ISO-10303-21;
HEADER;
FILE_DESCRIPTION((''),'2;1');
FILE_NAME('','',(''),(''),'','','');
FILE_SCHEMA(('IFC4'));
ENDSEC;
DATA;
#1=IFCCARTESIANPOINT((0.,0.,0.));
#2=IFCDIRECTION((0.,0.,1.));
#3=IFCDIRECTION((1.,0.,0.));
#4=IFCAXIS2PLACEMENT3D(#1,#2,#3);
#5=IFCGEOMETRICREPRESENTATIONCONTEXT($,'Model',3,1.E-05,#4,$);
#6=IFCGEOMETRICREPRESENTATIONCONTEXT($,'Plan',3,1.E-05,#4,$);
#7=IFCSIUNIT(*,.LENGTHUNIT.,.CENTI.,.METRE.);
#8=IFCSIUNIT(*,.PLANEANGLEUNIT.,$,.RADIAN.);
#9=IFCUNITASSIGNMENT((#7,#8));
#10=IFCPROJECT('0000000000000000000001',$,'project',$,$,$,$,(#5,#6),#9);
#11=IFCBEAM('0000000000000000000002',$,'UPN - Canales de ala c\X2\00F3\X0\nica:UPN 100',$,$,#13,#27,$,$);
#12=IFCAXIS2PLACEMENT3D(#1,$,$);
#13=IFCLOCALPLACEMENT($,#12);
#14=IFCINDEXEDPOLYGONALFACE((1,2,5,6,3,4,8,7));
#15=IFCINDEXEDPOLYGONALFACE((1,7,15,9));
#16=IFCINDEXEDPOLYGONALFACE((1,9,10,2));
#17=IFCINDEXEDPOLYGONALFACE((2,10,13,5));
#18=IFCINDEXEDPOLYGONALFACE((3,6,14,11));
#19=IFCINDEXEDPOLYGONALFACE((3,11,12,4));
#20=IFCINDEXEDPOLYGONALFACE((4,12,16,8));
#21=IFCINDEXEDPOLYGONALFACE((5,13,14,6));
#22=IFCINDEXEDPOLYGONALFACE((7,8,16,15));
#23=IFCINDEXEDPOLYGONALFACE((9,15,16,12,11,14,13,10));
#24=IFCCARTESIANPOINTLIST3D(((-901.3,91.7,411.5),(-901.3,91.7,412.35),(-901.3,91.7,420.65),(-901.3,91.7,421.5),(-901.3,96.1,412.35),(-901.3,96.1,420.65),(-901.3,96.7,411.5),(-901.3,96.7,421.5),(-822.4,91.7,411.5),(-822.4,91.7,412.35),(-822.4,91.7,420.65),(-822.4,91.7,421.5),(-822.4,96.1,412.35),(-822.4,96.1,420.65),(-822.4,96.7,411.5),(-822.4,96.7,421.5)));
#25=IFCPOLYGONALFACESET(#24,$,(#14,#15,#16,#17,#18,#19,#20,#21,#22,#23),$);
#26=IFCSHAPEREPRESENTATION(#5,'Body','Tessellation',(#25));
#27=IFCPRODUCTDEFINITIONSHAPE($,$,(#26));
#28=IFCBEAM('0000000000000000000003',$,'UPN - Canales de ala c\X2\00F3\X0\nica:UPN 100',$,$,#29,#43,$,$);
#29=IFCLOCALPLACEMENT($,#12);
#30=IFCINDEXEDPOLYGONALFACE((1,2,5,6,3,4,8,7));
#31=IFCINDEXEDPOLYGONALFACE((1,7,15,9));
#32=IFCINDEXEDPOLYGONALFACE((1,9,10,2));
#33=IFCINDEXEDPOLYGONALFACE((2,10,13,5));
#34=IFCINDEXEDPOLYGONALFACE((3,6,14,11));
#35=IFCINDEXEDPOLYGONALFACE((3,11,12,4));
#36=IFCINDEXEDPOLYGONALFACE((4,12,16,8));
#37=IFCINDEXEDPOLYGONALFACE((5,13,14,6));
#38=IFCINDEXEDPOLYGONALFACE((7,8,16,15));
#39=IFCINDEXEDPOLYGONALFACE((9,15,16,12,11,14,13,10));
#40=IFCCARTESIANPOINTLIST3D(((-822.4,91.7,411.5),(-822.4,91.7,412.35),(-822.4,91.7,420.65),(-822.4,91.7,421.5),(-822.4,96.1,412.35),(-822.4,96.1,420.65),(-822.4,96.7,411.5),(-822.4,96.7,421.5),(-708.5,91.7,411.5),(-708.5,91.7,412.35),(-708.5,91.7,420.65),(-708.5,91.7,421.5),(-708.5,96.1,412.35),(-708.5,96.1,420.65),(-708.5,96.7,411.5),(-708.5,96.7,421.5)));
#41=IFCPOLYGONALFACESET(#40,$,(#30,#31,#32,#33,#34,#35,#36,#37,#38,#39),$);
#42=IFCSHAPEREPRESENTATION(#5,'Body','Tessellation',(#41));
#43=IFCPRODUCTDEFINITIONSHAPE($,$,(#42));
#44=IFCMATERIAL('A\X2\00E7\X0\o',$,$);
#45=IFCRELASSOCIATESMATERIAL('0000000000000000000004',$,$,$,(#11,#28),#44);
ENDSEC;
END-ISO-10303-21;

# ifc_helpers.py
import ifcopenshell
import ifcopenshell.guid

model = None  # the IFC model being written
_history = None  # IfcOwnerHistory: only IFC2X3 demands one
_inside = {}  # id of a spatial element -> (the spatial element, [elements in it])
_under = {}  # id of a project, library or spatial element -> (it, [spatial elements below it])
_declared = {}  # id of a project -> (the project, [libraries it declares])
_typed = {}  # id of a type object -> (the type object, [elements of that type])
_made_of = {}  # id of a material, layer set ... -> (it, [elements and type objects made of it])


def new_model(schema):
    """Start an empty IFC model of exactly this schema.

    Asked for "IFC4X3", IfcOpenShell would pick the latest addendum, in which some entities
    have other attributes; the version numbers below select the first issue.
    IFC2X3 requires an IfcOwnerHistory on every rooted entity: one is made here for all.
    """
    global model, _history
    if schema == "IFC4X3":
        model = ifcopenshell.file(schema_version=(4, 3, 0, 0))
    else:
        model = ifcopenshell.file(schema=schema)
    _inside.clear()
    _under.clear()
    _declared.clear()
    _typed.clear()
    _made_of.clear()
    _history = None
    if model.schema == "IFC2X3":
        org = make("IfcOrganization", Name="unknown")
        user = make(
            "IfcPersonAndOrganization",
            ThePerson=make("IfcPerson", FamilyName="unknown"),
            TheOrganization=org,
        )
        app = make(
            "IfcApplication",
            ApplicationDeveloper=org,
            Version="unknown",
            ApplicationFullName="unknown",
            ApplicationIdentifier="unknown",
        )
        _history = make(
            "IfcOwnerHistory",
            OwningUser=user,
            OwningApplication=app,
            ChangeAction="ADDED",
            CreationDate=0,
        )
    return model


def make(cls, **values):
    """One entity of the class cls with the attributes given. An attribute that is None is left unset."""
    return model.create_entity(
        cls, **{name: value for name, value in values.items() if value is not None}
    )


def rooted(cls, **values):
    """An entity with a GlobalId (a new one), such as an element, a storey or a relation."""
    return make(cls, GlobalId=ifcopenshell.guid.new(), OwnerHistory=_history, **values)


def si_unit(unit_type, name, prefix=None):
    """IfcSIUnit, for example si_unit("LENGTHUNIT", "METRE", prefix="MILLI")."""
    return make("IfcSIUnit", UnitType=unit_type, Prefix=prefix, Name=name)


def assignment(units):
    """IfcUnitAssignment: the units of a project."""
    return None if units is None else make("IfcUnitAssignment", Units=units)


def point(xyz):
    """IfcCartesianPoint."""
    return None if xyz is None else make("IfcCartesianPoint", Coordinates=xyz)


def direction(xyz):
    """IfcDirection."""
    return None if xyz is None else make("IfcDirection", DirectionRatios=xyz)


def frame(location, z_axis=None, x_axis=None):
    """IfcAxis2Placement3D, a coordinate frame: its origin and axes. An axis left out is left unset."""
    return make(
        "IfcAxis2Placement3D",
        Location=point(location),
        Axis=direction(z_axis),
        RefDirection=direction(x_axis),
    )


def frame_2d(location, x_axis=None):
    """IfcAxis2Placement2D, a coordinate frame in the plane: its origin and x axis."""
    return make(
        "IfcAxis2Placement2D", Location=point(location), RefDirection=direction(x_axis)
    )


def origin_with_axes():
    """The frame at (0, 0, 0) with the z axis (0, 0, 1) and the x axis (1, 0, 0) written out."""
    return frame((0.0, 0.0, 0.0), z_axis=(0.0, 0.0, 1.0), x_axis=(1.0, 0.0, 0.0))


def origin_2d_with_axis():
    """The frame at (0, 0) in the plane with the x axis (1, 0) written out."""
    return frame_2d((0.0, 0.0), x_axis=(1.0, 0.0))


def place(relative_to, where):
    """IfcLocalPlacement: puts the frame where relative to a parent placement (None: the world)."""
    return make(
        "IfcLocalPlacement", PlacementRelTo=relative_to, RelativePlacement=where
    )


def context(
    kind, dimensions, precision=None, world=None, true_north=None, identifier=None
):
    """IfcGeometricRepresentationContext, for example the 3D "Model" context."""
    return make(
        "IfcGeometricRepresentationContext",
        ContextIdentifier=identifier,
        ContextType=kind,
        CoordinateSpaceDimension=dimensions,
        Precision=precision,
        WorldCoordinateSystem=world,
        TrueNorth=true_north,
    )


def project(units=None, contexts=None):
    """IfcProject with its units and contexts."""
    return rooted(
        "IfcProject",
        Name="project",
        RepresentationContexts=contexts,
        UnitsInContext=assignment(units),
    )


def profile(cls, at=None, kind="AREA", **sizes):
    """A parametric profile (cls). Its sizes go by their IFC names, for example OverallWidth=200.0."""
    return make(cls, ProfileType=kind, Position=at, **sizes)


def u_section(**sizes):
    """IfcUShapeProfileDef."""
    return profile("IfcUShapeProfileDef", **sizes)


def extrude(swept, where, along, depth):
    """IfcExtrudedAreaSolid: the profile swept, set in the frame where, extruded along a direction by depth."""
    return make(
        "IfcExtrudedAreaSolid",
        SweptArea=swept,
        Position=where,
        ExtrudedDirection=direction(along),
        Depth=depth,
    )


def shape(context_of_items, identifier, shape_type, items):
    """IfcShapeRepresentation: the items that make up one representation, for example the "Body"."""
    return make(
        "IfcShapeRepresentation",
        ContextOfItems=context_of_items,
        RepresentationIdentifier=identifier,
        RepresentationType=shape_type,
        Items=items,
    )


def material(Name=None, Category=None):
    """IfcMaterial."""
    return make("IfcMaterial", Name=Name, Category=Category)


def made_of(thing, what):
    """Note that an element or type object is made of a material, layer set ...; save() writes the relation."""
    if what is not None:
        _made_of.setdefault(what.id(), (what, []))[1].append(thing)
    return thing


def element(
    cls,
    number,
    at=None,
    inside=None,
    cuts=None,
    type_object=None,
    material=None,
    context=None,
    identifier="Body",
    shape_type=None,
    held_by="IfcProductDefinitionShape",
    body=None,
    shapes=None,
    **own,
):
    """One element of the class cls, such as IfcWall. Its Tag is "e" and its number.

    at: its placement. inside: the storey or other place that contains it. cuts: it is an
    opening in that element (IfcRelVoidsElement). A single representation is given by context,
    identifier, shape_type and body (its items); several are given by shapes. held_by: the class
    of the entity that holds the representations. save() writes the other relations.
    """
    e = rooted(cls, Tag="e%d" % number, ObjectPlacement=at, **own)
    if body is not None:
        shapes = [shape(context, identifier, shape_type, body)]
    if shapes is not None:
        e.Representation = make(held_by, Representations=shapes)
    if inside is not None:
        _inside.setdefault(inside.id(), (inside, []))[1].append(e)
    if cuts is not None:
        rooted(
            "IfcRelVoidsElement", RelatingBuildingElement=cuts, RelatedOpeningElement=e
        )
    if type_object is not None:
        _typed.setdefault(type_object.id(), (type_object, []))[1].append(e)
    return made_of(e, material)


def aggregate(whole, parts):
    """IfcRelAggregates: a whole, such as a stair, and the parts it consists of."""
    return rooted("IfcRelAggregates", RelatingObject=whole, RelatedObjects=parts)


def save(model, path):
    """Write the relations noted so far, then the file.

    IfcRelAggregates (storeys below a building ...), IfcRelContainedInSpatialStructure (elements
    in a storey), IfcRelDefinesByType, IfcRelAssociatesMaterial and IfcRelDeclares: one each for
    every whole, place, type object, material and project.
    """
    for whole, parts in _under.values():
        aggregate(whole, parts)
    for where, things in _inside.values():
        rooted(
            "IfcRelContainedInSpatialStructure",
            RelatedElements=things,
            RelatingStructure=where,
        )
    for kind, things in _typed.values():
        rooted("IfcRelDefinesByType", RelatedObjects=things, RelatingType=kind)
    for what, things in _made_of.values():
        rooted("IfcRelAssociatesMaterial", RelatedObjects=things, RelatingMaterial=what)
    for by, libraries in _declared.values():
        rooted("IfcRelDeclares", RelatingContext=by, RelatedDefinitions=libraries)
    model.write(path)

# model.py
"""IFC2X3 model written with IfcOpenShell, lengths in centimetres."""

from ifc_helpers import new_model, si_unit, frame, origin_with_axes, origin_2d_with_axis, place, context, project, u_section, extrude, material, element, save


model = new_model("IFC2X3")

# Units and contexts
model_context = context("Model", 3, precision=1e-05, world=origin_with_axes())
plan_context = context("Plan", 3, precision=1e-05, world=origin_with_axes())
ifc_project = project(units=[si_unit("LENGTHUNIT", "METRE", prefix="CENTI"), si_unit("PLANEANGLEUNIT", "RADIAN")], contexts=[model_context, plan_context])

# Shared definitions
ifc_material = material(Name="Aço")

# Beams
beam_1_placement = place(None, frame((-822.4, 94.2, 416.5), z_axis=(-1.0, 0.0, 0.0), x_axis=(0.0, -1.0, 0.0)))
element("IfcBeam", 1, at=beam_1_placement, material=ifc_material, Name="UPN - Canales de ala cónica:UPN 100", context=model_context, shape_type="SweptSolid", body=[
    extrude(u_section(Depth=10.0, FlangeWidth=5.0, WebThickness=0.6, FlangeThickness=0.85, FilletRadius=0.0, EdgeRadius=0.0, FlangeSlope=0.0, CentreOfGravityInX=0.0, at=origin_2d_with_axis()), origin_with_axes(), (0.0, 0.0, 1.0), 78.9),
])
beam_2_placement = place(None, frame((-708.5, 94.2, 416.5), z_axis=(-1.0, 0.0, 0.0), x_axis=(0.0, -1.0, 0.0)))
element("IfcBeam", 2, at=beam_2_placement, material=ifc_material, Name="UPN - Canales de ala cónica:UPN 100", context=model_context, shape_type="SweptSolid", body=[
    extrude(u_section(Depth=10.0, FlangeWidth=5.0, WebThickness=0.6, FlangeThickness=0.85, FilletRadius=0.0, EdgeRadius=0.0, FlangeSlope=0.0, CentreOfGravityInX=0.0, at=origin_2d_with_axis()), origin_with_axes(), (0.0, 0.0, 1.0), 113.9),
])

save(model, "model.ifc")
